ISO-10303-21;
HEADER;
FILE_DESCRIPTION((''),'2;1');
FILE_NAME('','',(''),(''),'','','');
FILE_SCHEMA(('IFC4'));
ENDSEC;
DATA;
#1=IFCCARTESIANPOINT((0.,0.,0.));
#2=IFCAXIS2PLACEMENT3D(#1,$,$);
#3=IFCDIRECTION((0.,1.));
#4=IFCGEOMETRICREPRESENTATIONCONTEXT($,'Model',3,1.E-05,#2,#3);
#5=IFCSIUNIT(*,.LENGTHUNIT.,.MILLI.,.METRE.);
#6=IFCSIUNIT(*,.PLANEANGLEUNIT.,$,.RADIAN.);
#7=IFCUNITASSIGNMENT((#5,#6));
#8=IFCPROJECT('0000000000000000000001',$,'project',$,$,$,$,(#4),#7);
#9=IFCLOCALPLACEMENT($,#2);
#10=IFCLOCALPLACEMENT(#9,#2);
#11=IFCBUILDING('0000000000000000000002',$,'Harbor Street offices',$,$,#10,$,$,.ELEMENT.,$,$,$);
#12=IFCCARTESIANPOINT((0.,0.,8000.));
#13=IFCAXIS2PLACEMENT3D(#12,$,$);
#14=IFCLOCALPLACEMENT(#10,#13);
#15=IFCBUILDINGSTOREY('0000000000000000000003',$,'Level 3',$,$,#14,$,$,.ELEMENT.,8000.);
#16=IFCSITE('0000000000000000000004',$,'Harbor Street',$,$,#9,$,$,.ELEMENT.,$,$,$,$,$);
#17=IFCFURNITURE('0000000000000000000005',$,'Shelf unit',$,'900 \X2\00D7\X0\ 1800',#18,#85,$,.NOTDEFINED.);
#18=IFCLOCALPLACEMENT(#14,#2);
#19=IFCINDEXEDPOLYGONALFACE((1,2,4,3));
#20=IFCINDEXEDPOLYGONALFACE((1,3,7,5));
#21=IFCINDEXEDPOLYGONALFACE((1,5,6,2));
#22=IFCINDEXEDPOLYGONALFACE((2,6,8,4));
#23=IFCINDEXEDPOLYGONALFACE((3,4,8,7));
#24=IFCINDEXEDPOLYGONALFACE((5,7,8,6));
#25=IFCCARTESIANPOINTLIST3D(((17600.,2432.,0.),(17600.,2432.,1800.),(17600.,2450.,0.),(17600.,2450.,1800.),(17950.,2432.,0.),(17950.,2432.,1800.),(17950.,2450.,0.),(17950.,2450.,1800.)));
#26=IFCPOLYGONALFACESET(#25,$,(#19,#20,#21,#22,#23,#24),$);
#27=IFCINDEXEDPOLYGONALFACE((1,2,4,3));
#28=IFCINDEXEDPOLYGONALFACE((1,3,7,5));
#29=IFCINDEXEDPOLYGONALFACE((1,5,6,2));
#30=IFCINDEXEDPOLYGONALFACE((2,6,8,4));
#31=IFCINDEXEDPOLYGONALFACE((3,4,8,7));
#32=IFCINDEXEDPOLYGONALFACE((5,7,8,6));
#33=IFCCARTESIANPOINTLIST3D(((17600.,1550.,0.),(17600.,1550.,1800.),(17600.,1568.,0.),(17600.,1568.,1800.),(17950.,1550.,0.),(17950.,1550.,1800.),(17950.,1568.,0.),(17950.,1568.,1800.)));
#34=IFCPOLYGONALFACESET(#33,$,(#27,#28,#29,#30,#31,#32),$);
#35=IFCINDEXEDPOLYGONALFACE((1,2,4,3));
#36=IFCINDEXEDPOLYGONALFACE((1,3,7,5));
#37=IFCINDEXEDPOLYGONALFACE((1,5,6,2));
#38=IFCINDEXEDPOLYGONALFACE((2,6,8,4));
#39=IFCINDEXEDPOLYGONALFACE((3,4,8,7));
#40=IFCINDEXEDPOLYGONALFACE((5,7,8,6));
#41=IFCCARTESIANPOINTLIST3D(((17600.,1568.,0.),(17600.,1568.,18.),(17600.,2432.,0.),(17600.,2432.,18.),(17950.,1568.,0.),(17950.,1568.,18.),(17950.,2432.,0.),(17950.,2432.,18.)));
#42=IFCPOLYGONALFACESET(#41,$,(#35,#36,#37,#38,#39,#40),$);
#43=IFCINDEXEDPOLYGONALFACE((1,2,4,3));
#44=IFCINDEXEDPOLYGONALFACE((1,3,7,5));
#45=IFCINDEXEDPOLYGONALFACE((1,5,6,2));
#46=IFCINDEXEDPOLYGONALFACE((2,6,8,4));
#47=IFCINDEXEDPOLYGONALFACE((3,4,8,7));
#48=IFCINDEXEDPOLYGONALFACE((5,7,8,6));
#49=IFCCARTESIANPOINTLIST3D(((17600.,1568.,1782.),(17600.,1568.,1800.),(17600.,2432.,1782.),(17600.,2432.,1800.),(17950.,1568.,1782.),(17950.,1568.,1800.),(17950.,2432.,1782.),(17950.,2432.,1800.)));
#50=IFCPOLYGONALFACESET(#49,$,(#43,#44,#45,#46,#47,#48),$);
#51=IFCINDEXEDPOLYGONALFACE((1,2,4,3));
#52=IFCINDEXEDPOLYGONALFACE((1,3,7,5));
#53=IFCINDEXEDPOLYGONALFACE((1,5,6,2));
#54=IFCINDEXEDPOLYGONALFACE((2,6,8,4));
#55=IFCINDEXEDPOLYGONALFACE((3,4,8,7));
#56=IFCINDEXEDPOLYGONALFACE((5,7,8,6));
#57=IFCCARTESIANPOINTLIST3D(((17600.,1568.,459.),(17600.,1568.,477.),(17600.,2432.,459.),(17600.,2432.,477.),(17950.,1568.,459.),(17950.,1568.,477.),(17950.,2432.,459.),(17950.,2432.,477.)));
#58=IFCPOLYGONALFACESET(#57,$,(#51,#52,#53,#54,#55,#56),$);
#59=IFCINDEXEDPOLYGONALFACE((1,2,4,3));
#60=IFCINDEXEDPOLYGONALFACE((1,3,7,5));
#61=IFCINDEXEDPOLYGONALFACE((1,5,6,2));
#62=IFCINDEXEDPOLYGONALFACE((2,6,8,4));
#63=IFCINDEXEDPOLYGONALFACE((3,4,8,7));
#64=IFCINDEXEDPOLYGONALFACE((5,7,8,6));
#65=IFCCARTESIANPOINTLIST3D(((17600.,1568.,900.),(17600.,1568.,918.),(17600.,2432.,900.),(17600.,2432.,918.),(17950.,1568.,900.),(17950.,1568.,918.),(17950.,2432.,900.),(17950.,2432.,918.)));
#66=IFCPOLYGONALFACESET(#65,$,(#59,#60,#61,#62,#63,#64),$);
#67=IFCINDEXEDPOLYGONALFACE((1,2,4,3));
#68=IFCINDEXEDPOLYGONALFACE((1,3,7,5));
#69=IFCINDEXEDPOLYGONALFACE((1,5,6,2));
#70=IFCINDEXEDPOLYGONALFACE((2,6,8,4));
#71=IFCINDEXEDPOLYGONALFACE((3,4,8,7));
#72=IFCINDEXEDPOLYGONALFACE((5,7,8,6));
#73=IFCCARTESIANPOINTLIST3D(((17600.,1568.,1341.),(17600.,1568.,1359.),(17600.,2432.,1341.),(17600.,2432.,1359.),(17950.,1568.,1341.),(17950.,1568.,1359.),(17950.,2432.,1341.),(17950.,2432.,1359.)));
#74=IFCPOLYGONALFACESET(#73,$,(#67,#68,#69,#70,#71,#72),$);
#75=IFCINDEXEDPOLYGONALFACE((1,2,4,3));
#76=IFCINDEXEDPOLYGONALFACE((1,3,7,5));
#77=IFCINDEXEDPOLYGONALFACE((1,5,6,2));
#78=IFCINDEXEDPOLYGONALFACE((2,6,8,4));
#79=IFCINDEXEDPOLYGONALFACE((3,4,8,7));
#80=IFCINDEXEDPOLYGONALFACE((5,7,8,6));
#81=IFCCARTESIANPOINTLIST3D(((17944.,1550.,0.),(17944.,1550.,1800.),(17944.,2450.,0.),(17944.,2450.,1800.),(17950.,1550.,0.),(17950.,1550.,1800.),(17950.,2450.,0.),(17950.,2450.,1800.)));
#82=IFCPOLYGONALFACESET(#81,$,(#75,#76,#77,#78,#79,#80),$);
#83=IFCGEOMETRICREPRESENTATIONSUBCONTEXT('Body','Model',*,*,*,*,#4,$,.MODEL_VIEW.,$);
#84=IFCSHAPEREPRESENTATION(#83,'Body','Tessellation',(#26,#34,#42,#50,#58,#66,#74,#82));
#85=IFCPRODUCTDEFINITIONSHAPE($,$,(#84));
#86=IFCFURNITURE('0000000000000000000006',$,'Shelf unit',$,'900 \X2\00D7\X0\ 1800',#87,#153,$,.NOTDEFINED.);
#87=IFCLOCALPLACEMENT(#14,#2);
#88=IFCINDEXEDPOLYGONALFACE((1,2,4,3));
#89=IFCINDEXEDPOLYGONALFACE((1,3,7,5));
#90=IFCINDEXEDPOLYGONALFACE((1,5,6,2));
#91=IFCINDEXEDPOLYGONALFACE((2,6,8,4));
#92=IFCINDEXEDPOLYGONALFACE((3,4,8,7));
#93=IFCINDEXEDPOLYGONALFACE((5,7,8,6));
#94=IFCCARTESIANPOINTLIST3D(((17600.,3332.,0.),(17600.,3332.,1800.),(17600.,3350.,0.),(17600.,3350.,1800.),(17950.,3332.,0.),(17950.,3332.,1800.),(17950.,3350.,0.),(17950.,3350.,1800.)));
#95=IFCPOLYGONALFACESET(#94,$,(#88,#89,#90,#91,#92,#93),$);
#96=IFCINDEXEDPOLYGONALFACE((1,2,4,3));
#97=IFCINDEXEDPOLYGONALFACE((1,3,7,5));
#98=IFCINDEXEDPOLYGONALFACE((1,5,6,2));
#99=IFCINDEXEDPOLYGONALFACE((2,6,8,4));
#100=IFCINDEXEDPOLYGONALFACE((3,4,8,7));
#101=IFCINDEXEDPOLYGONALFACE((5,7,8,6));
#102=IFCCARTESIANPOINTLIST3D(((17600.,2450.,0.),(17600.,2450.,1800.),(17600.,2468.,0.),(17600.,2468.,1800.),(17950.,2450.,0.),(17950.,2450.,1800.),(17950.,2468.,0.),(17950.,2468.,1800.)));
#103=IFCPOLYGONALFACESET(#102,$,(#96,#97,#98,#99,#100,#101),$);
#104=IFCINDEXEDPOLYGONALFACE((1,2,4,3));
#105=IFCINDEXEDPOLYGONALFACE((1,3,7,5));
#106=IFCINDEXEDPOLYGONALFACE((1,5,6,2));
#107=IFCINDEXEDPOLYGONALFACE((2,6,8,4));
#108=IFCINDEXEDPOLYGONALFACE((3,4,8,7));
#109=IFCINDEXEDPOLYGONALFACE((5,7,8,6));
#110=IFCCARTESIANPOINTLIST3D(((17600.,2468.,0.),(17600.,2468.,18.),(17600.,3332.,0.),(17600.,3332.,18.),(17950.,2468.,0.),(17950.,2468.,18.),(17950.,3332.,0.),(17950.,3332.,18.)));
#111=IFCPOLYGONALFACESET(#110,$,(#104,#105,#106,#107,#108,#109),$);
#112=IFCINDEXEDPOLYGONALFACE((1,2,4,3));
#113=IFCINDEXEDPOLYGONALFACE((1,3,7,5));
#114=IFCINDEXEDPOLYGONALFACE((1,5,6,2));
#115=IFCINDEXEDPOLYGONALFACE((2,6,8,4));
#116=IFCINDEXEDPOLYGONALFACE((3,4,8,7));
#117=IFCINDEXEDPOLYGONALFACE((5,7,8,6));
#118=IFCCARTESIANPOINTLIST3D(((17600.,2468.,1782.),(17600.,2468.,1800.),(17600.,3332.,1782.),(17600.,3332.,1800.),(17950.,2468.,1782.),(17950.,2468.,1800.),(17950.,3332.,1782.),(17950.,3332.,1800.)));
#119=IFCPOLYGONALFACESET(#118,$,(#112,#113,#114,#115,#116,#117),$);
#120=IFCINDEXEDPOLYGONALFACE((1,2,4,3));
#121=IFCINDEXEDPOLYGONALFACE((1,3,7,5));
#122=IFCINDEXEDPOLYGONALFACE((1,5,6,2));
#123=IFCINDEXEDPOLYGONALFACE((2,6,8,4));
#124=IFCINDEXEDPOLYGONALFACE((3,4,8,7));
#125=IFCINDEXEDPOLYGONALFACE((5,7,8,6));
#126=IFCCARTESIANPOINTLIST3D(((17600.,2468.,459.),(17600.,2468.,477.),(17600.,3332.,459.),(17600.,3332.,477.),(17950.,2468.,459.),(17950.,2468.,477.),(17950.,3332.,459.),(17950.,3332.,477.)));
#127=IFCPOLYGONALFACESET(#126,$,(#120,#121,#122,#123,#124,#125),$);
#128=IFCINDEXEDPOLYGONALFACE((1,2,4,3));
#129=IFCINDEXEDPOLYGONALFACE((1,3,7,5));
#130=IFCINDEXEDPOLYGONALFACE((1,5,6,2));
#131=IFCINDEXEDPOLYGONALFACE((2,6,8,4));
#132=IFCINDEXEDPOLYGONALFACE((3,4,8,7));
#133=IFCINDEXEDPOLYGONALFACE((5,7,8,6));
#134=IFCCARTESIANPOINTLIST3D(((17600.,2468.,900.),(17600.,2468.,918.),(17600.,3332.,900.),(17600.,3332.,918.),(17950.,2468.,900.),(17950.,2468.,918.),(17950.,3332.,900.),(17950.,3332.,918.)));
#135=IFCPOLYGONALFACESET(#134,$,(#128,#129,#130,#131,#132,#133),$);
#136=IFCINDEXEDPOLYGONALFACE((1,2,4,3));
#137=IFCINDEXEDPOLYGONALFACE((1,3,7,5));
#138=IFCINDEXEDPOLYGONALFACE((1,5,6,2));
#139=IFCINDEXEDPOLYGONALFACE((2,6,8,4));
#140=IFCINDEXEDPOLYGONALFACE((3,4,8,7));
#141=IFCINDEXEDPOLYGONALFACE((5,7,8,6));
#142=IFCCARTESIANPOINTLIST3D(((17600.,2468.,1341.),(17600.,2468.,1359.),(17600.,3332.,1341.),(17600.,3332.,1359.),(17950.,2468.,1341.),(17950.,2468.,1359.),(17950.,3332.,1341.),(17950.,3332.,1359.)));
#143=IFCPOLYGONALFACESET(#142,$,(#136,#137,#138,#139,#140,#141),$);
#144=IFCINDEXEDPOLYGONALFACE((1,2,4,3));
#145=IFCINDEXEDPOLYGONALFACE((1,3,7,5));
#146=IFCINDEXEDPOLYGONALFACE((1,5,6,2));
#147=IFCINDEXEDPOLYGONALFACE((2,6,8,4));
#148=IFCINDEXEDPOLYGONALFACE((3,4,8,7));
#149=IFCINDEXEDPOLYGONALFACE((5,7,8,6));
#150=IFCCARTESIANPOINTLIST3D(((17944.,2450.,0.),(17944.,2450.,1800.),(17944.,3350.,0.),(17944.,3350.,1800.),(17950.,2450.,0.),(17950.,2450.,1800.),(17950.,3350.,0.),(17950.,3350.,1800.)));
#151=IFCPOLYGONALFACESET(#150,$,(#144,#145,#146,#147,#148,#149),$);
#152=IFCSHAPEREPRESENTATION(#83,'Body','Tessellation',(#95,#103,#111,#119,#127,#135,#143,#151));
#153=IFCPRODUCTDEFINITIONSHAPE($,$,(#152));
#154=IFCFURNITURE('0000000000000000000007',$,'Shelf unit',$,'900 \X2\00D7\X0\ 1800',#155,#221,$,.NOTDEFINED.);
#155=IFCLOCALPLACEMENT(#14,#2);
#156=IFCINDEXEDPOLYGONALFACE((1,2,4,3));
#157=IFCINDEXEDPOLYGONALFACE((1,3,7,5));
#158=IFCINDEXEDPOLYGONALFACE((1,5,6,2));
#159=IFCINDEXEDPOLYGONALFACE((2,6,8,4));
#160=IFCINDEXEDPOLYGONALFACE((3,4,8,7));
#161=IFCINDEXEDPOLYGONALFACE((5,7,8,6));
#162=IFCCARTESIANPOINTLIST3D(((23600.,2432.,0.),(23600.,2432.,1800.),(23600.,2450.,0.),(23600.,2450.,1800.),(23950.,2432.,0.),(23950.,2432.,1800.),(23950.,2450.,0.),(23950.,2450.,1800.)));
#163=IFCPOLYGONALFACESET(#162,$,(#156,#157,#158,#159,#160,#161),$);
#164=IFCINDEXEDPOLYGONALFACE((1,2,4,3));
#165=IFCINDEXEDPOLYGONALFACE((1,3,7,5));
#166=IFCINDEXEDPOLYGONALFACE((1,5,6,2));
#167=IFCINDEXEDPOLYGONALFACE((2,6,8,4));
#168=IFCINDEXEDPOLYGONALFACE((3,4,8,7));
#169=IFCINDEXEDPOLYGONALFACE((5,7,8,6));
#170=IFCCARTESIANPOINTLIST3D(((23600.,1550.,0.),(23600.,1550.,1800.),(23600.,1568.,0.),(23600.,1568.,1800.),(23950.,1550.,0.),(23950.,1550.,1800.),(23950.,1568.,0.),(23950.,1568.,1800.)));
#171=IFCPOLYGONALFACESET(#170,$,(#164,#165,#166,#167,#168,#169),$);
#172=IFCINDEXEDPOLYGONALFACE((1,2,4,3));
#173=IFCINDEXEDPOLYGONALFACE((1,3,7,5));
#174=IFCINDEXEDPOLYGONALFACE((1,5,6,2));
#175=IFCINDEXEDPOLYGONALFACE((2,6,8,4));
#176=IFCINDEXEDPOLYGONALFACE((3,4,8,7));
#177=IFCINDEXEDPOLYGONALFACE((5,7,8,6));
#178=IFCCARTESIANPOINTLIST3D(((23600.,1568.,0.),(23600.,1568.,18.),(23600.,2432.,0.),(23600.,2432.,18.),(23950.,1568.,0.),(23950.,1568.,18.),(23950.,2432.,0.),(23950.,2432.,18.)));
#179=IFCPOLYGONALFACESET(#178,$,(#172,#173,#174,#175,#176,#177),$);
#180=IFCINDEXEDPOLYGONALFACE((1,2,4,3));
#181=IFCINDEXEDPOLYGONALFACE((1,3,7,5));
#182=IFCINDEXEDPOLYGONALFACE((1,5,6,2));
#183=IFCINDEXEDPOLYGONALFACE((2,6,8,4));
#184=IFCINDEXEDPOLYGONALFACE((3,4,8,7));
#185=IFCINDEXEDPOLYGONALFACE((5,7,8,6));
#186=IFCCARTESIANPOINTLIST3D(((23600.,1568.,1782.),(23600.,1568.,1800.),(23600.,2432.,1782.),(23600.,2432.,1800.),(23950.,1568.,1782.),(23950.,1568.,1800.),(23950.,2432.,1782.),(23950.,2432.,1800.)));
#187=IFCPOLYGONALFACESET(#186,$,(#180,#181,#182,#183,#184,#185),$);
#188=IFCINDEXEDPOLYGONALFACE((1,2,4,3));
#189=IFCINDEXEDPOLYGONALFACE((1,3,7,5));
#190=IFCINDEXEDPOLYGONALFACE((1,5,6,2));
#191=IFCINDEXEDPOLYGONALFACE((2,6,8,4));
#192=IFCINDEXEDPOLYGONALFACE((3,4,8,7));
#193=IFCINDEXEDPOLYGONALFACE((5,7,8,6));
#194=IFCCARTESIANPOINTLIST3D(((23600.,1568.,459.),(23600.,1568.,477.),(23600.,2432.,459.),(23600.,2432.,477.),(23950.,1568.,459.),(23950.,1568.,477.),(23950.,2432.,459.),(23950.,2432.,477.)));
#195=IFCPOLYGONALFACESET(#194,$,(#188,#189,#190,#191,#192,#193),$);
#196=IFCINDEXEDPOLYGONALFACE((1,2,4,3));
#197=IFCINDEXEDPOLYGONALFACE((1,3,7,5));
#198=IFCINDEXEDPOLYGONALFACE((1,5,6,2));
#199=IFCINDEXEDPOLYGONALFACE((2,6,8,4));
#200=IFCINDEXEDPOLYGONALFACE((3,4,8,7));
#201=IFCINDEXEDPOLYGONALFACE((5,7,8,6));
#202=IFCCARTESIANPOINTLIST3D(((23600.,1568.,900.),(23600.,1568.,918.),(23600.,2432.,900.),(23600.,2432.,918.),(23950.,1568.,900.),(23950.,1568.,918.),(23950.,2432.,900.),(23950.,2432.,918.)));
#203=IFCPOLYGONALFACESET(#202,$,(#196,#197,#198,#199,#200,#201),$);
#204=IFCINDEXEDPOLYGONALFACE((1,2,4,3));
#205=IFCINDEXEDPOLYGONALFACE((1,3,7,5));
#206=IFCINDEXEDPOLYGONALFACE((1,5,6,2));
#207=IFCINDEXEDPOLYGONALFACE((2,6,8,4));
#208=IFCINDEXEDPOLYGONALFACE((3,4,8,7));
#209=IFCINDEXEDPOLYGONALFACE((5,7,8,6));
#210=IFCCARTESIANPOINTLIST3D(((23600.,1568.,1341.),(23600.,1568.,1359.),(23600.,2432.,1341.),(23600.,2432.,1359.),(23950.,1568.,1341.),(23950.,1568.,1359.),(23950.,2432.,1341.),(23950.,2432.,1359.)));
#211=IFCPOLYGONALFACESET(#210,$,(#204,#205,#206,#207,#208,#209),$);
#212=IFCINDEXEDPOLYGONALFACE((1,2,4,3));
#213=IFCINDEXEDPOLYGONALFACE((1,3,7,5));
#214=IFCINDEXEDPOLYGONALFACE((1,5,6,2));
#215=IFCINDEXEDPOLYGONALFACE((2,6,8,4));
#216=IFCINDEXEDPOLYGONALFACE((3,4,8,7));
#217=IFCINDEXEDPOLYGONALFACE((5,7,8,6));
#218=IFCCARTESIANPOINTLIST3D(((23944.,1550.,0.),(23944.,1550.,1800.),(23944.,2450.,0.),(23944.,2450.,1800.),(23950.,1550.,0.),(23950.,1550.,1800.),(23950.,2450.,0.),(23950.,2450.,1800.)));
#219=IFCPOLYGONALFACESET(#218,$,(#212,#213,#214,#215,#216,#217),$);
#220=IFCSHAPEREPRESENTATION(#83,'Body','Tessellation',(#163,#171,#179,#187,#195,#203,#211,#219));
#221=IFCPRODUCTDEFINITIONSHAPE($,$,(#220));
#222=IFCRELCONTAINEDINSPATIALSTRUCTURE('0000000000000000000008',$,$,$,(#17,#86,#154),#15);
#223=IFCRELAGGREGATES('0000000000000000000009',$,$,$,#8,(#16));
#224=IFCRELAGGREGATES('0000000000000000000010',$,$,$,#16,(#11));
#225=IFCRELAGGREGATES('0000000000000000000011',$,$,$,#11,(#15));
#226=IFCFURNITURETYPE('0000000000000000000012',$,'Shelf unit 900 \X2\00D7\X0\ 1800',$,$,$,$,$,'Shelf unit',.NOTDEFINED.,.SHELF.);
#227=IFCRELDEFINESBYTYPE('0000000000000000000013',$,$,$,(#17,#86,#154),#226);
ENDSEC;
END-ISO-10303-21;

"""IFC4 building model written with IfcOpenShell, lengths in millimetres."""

from ifc_helpers import new_model, si_unit, direction, frame, origin, place, context, subcontext, project, spatial, polyline, outline, extrude, source, transform, mapped, type_object, type_shapes, element, save


model = new_model("IFC4")

# Units and contexts
model_context = context("Model", 3, precision=1e-05, world=origin(), true_north=direction((0.0, 1.0)))
body_context = subcontext(model_context, "Body", "Model", "MODEL_VIEW")
ifc_project = project(units=[si_unit("LENGTHUNIT", "METRE", prefix="MILLI"), si_unit("PLANEANGLEUNIT", "RADIAN")], contexts=[model_context])

# Site, building, storey
site_placement = place(None, origin())
site = spatial("IfcSite", under=ifc_project, at=site_placement, Name="Harbor Street", CompositionType="ELEMENT")
building_placement = place(site_placement, origin())
building = spatial("IfcBuilding", under=site, at=building_placement, Name="Harbor Street offices", CompositionType="ELEMENT")
storey_placement = place(building_placement, frame((0.0, 0.0, 8000.0)))
storey = spatial("IfcBuildingStorey", under=building, at=storey_placement, Name="Level 3", CompositionType="ELEMENT", Elevation=8000.0)

# Furniture
furniture_type_1 = type_object("IfcFurnitureType", Name="Shelf unit 900 × 1800", ElementType="Shelf unit", AssemblyPlace="NOTDEFINED", PredefinedType="SHELF")
shared_shape_1 = source(origin(), body_context, "Body", "SweptSolid", [
    extrude(outline(polyline([(-450.0, 0.0), (-432.0, 0.0), (-432.0, 350.0), (-450.0, 350.0), (-450.0, 0.0)])), origin(), (0.0, 0.0, 1.0), 1800.0),
    extrude(outline(polyline([(432.0, 0.0), (450.0, 0.0), (450.0, 350.0), (432.0, 350.0), (432.0, 0.0)])), origin(), (0.0, 0.0, 1.0), 1800.0),
    extrude(outline(polyline([(-432.0, 0.0), (432.0, 0.0), (432.0, 350.0), (-432.0, 350.0), (-432.0, 0.0)])), origin(), (0.0, 0.0, 1.0), 18.0),
    extrude(outline(polyline([(-432.0, 0.0), (432.0, 0.0), (432.0, 350.0), (-432.0, 350.0), (-432.0, 0.0)])), frame((0.0, 0.0, 1782.0)), (0.0, 0.0, 1.0), 18.0),
    extrude(outline(polyline([(-432.0, 0.0), (432.0, 0.0), (432.0, 350.0), (-432.0, 350.0), (-432.0, 0.0)])), frame((0.0, 0.0, 459.0)), (0.0, 0.0, 1.0), 18.0),
    extrude(outline(polyline([(-432.0, 0.0), (432.0, 0.0), (432.0, 350.0), (-432.0, 350.0), (-432.0, 0.0)])), frame((0.0, 0.0, 900.0)), (0.0, 0.0, 1.0), 18.0),
    extrude(outline(polyline([(-432.0, 0.0), (432.0, 0.0), (432.0, 350.0), (-432.0, 350.0), (-432.0, 0.0)])), frame((0.0, 0.0, 1341.0)), (0.0, 0.0, 1.0), 18.0),
    extrude(outline(polyline([(-450.0, 344.0), (450.0, 344.0), (450.0, 350.0), (-450.0, 350.0), (-450.0, 344.0)])), origin(), (0.0, 0.0, 1.0), 1800.0),
])
type_shapes(furniture_type_1, [shared_shape_1])
for number, where, z_axis, x_axis, name in (
    (1, (17600.0, 2000.0, 0.0), (0.0, 0.0, 1.0), (0.0, -1.0, 0.0), "Shelf unit"),
    (2, (17600.0, 2900.0, 0.0), (0.0, 0.0, 1.0), (0.0, -1.0, 0.0), "Shelf unit"),
    (3, (23600.0, 2000.0, 0.0), (0.0, 0.0, 1.0), (0.0, -1.0, 0.0), "Shelf unit"),
):
    element("IfcFurniture", number, at=place(storey_placement, frame(where, z_axis=z_axis, x_axis=x_axis)), inside=storey, type_object=furniture_type_1, Name=name, ObjectType="900 × 1800", PredefinedType="NOTDEFINED", context=body_context, shape_type="MappedRepresentation", body=[
        mapped(shared_shape_1, transform((0.0, 0.0, 0.0))),
    ])

save(model, "model.ifc")
